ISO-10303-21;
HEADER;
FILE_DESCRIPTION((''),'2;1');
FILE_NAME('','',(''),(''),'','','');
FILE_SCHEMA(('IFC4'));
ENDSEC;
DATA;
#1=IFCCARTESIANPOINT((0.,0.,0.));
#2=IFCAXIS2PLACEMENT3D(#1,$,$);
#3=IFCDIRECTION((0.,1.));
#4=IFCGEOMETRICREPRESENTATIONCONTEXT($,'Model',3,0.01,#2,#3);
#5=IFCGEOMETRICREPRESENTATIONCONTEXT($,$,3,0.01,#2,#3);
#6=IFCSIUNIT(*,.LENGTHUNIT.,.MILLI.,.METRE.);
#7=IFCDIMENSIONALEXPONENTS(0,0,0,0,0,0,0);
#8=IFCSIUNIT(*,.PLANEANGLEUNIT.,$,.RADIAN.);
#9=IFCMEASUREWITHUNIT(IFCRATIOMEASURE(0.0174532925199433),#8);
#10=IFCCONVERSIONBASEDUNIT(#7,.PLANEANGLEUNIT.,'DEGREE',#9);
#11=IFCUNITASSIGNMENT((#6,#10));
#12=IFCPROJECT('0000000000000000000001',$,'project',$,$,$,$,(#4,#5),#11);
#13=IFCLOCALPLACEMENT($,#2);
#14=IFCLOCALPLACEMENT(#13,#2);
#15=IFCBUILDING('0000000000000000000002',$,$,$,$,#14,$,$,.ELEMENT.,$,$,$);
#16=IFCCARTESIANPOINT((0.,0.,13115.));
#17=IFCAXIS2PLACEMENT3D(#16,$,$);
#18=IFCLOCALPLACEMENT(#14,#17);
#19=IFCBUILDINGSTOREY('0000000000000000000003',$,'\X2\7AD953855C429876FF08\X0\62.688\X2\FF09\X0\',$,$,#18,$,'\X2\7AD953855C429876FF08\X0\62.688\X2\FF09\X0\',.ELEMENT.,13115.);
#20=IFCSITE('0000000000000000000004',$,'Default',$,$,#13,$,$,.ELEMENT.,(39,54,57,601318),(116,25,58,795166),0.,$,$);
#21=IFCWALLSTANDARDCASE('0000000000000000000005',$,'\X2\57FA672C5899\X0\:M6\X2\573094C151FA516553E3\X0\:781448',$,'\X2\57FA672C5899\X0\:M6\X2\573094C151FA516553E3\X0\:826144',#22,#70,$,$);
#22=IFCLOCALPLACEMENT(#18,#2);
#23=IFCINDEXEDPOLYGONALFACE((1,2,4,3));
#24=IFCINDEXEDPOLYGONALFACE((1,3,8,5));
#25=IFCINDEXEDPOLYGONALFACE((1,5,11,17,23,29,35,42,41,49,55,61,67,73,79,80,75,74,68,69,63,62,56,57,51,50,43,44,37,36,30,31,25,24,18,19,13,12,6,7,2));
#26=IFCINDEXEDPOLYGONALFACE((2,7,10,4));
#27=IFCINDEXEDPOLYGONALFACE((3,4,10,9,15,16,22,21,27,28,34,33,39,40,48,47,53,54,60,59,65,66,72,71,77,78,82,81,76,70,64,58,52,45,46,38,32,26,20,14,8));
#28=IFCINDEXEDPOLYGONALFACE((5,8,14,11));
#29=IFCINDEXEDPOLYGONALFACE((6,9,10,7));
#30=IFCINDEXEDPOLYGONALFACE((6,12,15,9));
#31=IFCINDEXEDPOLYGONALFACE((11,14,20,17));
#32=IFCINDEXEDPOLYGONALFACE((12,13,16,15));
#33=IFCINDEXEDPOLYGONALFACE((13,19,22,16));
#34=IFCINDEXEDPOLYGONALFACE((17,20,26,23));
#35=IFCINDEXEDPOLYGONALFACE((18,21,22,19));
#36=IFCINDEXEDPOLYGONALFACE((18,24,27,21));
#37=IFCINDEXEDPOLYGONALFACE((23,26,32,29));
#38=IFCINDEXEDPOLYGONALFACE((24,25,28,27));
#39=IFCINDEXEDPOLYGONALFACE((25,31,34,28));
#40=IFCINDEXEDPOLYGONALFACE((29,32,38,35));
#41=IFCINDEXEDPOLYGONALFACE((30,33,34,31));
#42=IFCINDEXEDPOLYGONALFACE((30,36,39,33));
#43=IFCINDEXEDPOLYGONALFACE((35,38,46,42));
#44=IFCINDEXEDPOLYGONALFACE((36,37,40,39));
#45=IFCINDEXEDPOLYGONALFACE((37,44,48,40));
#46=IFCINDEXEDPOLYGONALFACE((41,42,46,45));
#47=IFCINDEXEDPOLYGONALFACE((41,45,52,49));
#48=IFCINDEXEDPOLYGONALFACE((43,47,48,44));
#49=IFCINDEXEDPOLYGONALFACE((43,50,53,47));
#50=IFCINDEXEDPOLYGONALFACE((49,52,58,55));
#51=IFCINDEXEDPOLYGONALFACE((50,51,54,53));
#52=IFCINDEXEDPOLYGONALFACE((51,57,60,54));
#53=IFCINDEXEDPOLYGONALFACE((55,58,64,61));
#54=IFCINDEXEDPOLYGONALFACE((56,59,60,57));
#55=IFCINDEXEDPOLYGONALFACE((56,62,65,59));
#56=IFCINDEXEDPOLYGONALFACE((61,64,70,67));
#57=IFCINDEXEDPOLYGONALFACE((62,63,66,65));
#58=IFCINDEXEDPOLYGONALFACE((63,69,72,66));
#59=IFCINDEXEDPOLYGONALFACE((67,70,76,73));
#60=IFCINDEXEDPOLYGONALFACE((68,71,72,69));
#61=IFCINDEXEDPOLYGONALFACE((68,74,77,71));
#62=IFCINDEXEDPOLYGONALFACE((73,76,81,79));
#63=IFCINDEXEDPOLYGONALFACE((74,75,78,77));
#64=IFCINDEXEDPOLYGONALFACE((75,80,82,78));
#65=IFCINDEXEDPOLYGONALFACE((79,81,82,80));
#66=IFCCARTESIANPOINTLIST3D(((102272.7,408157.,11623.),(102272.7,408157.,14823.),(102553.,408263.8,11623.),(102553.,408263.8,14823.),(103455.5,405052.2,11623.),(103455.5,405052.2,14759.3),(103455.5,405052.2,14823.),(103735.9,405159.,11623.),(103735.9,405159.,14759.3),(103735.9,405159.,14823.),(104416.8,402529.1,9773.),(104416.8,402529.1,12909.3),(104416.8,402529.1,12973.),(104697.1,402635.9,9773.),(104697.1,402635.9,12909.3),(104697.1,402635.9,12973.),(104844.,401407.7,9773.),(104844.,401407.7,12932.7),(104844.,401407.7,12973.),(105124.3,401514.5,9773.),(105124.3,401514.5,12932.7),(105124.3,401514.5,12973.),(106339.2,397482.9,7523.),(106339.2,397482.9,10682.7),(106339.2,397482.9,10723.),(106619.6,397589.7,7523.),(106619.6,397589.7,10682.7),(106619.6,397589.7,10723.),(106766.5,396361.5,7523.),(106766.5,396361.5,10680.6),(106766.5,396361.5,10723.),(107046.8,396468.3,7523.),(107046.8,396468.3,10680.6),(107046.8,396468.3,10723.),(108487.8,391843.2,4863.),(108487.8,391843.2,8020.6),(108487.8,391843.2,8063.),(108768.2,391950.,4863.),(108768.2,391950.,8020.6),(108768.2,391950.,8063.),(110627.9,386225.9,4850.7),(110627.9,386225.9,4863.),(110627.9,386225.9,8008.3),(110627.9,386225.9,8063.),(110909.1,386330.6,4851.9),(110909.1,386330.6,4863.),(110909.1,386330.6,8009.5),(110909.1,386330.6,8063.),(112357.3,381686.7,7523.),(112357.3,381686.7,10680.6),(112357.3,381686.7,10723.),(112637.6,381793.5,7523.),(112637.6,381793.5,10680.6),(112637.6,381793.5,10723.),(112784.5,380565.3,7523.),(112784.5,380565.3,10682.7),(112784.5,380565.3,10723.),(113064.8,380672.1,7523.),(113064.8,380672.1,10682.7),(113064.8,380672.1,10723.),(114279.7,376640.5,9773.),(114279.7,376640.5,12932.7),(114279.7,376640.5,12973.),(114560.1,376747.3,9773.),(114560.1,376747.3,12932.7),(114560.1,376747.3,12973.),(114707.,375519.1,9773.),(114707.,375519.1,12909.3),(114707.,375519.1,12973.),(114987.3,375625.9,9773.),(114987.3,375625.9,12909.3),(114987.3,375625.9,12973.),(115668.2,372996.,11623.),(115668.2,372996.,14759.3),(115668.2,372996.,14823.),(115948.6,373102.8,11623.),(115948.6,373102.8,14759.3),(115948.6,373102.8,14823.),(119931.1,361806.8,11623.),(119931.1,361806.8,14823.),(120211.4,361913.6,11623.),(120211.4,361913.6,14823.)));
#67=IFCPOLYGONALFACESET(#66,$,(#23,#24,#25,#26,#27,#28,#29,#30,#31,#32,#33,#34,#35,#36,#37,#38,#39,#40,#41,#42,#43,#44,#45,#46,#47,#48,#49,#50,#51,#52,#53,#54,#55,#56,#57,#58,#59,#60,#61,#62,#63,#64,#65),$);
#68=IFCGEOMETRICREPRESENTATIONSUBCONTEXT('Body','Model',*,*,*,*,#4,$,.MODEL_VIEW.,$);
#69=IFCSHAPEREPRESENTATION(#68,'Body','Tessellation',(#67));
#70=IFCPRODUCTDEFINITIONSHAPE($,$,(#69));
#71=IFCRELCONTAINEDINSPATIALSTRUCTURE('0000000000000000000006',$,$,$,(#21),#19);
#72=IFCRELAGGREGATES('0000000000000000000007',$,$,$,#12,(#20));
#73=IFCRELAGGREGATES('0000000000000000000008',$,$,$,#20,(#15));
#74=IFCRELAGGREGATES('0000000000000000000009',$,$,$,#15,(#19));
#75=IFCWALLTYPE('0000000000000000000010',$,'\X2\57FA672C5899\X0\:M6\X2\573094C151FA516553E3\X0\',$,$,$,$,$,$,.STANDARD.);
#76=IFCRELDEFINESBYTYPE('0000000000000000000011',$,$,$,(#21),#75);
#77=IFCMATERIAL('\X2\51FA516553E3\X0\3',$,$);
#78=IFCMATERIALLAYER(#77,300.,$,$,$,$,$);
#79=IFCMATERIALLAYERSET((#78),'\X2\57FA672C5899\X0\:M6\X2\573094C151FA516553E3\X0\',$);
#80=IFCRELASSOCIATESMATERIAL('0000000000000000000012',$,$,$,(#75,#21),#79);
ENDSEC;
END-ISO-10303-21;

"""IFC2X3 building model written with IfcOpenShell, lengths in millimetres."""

from ifc_helpers import new_model, entity, si_unit, converted_unit, direction, frame, frame_2d, origin, place, context, subcontext, project, spatial, polyline, rectangle, extrude, clip, bounded_halfspace, material, layer, layer_set, layer_usage, type_object, element, save


model = new_model("IFC2X3")

# Units and contexts
model_context = context("Model", 3, precision=0.01, world=origin(), true_north=direction((0.0, 1.0)))
context_of_model = context(None, 3, precision=0.01, world=origin(), true_north=direction((0.0, 1.0)))
body_context = subcontext(model_context, "Body", "Model", "MODEL_VIEW")
ifc_project = project(units=[si_unit("LENGTHUNIT", "METRE", prefix="MILLI"), converted_unit("PLANEANGLEUNIT", "DEGREE", entity("IfcRatioMeasure", 0.0174532925199433), si_unit("PLANEANGLEUNIT", "RADIAN"), dimensions=[0, 0, 0, 0, 0, 0, 0])], contexts=[model_context, context_of_model])

# Site, building, storey
site_placement = place(None, origin())
site = spatial("IfcSite", under=ifc_project, at=site_placement, Name="Default", CompositionType="ELEMENT", RefLatitude=(39, 54, 57, 601318), RefLongitude=(116, 25, 58, 795166), RefElevation=0.0)
building_placement = place(site_placement, origin())
building = spatial("IfcBuilding", under=site, at=building_placement, CompositionType="ELEMENT")
storey_placement = place(building_placement, frame((0.0, 0.0, 13115.0)))
storey = spatial("IfcBuildingStorey", under=building, at=storey_placement, Name="站厅层顶（62.688）", LongName="站厅层顶（62.688）", CompositionType="ELEMENT", Elevation=13115.0)

# Wall
ifc_material_1 = material(Name="出入口3")
ifc_layer_1 = layer(ifc_material_1, 300.0)
ifc_layer_set_1 = layer_set([ifc_layer_1], Name="基本墙:M6地铁出入口")
wall_type = type_object("IfcWallType", Name="基本墙:M6地铁出入口", PredefinedType="STANDARD", material=ifc_layer_set_1)
ifc_layer_usage_1 = layer_usage(ifc_layer_set_1, "AXIS2", "NEGATIVE", 150.0)
wall_1_placement = place(storey_placement, frame((102412.8, 408210.4, 0.0), z_axis=(0.0, 0.0, 1.0), x_axis=(0.356017, -0.93448, 0.0)))
solid_1 = clip(clip(clip(clip(clip(clip(clip(clip(extrude(rectangle(XDim=49600.0, YDim=300.0, at=frame_2d((24800.0, 0.0), x_axis=(-1.0, 0.0))), origin(), (0.0, 0.0, 1.0), 14823.0), bounded_halfspace(frame((0.0, -150.0, 14823.0), z_axis=(0.0, 0.0, -1.0), x_axis=(0.0, -1.0, 0.0)), True, frame((0.0, -150.0, 14823.0)), polyline([(0.0, 0.0), (3322.5, 0.0), (3322.5, 300.0), (0.0, 300.0), (0.0, 0.0)]))), bounded_halfspace(frame((3322.5, -150.0, 14759.3), z_axis=(-0.565231, 0.0, -0.824932), x_axis=(0.824932, 0.0, -0.565231)), True, frame((3322.5, -150.0, 14759.3)), polyline([(0.0, 0.0), (2700.0, 0.0), (2700.0, 300.0), (0.0, 300.0), (0.0, 0.0)]))), bounded_halfspace(frame((6022.5, -150.0, 12973.0), z_axis=(0.0, 0.0, -1.0), x_axis=(0.0, 1.0, 0.0)), True, frame((6022.5, -150.0, 12973.0)), polyline([(0.0, 0.0), (1200.0, 0.0), (1200.0, 300.0), (0.0, 300.0), (0.0, 0.0)]))), bounded_halfspace(frame((7222.5, -150.0, 12932.7), z_axis=(-0.472221, 0.0, -0.88148), x_axis=(0.88148, 0.0, -0.472221)), True, frame((7222.5, -150.0, 12932.7)), polyline([(0.0, 0.0), (4200.0, 0.0), (4200.0, 300.0), (0.0, 300.0), (0.0, 0.0)]))), bounded_halfspace(frame((28326.2, -150.0, 10723.0), z_axis=(0.0, 0.0, -1.0), x_axis=(-1.0, 0.000005, 0.0)), True, frame((28326.2, -150.0, 10723.0)), polyline([(0.0, 0.0), (1200.0, 0.0), (1200.0, 300.0), (0.0, 300.0), (0.0, 0.0)]))), bounded_halfspace(frame((29526.2, -150.0, 10682.7), z_axis=(0.472221, -0.000002, -0.88148), x_axis=(-0.88148, 0.000004, -0.472221)), True, frame((29526.2, -150.0, 10682.7)), polyline([(0.0, 0.0), (4200.0, 0.0), (4200.0, 300.0), (0.0, 300.0), (0.0, 0.0)]))), bounded_halfspace(frame((11422.5, -150.0, 10723.0), z_axis=(0.0, 0.0, -1.0), x_axis=(0.0, 1.0, 0.0)), True, frame((11422.5, -150.0, 10723.0)), polyline([(0.0, 0.0), (1200.0, 0.0), (1200.0, 300.0), (0.0, 300.0), (0.0, 0.0)]))), bounded_halfspace(frame((12622.5, -150.0, 10680.6), z_axis=(-0.482018, 0.0, -0.876161), x_axis=(0.876161, 0.0, -0.482018)), True, frame((12622.5, -150.0, 10680.6)), polyline([(0.0, 0.0), (4835.1, 0.0), (4835.1, 300.0), (0.0, 300.0), (0.0, 0.0)])))
solid_2 = clip(clip(clip(clip(clip(clip(clip(clip(solid_1, bounded_halfspace(frame((17457.6, -150.0, 8063.0), z_axis=(0.0, 0.0, -1.0), x_axis=(0.0, 1.0, 0.0)), True, frame((17457.6, -150.0, 8063.0)), polyline([(0.0, 0.0), (6011.2, 0.0), (6013.4, 300.0), (0.0, 300.0), (0.0, 0.0)]))), bounded_halfspace(frame((23468.8, -150.0, 8008.3), z_axis=(0.482018, -0.000002, -0.876161), x_axis=(-0.876161, 0.000004, -0.482018)), True, frame((23468.8, -150.0, 8008.3)), polyline([(0.0, 0.0), (4857.5, 0.0), (4857.5, 300.0), (2.2, 300.0), (0.0, 0.0)]))), bounded_halfspace(frame((33726.2, -150.0, 12973.0), z_axis=(0.0, 0.0, -1.0), x_axis=(-1.0, 0.000005, 0.0)), True, frame((33726.2, -150.0, 12973.0)), polyline([(0.0, 0.0), (1200.0, 0.0), (1200.0, 300.0), (0.0, 300.0), (0.0, 0.0)]))), bounded_halfspace(frame((34926.2, -150.0, 12909.3), z_axis=(0.565231, -0.000003, -0.824932), x_axis=(-0.824932, 0.000004, -0.565231)), True, frame((34926.2, -150.0, 12909.3)), polyline([(0.0, 0.0), (2700.0, 0.0), (2700.0, 300.0), (0.0, 300.0), (0.0, 0.0)]))), bounded_halfspace(frame((37626.2, -150.0, 14823.0), z_axis=(0.0, 0.0, -1.0), x_axis=(0.000005, 1.0, 0.0)), True, frame((37626.2, -150.0, 14823.0)), polyline([(0.0, 0.0), (11973.8, 0.0), (11973.8, 300.0), (0.0, 300.0), (0.0, 0.0)]))), bounded_halfspace(frame((12622.5, -150.0, 7523.0), z_axis=(0.0, 0.0, 1.0), x_axis=(0.0, -1.0, 0.0)), True, frame((12622.5, -150.0, 7523.0)), polyline([(0.0, 0.0), (0.0, 300.0), (-1200.0, 300.0), (-1200.0, 0.0), (0.0, 0.0)]))), bounded_halfspace(frame((17457.6, -150.0, 4863.0), z_axis=(0.482018, 0.0, 0.876161), x_axis=(-0.876161, 0.0, 0.482018)), True, frame((17457.6, -150.0, 4863.0)), polyline([(0.0, 0.0), (0.0, 300.0), (-4835.1, 300.0), (-4835.1, 0.0), (0.0, 0.0)]))), bounded_halfspace(frame((23468.8, -150.0, 4863.0), z_axis=(0.0, 0.0, 1.0), x_axis=(0.0, -1.0, 0.0)), True, frame((23468.8, -150.0, 4863.0)), polyline([(0.0, 0.0), (2.2, 300.0), (-6011.2, 300.0), (-6011.2, 0.0), (-5146.3, 0.0), (-4496.3, 0.0), (-1546.3, 0.0), (-896.3, 0.0), (0.0, 0.0)])))
solid_3 = clip(clip(clip(clip(clip(clip(clip(clip(solid_2, bounded_halfspace(frame((28326.2, -150.0, 7523.0), z_axis=(-0.482018, 0.000002, 0.876161), x_axis=(0.876161, -0.000004, 0.482018)), True, frame((28326.2, -150.0, 7523.0)), polyline([(0.0, 0.0), (0.0, 300.0), (-4855.2, 300.0), (-4857.5, 0.0), (0.0, 0.0)]))), bounded_halfspace(frame((34926.2, -150.0, 9773.0)), True, frame((34926.2, -150.0, 9773.0)), polyline([(0.0, 0.0), (0.0, 300.0), (-1200.0, 300.0), (-1200.0, 0.0), (0.0, 0.0)]))), bounded_halfspace(frame((49600.0, -150.0, 11623.0), z_axis=(0.0, 0.0, 1.0), x_axis=(-0.000005, -1.0, 0.0)), True, frame((49600.0, -150.0, 11623.0)), polyline([(0.0, 0.0), (0.0, 300.0), (-11973.8, 300.0), (-11973.8, 0.0), (0.0, 0.0)]))), bounded_halfspace(frame((37626.2, -150.0, 11623.0), z_axis=(-0.565231, 0.000003, 0.824932), x_axis=(0.824932, -0.000004, 0.565231)), True, frame((37626.2, -150.0, 11623.0)), polyline([(0.0, 0.0), (0.0, 300.0), (-2700.0, 300.0), (-2700.0, 0.0), (0.0, 0.0)]))), bounded_halfspace(frame((6022.5, -150.0, 9773.0), z_axis=(0.565231, 0.0, 0.824932), x_axis=(-0.824932, 0.0, 0.565231)), True, frame((6022.5, -150.0, 9773.0)), polyline([(0.0, 0.0), (0.0, 300.0), (-2700.0, 300.0), (-2700.0, 0.0), (0.0, 0.0)]))), bounded_halfspace(frame((3322.5, -150.0, 11623.0), z_axis=(0.0, 0.0, 1.0), x_axis=(0.0, 1.0, 0.0)), True, frame((3322.5, -150.0, 11623.0)), polyline([(0.0, 0.0), (0.0, 300.0), (-3322.5, 300.0), (-3322.5, 0.0), (0.0, 0.0)]))), bounded_halfspace(frame((7222.5, -150.0, 9773.0), z_axis=(0.0, 0.0, 1.0), x_axis=(0.0, -1.0, 0.0)), True, frame((7222.5, -150.0, 9773.0)), polyline([(0.0, 0.0), (0.0, 300.0), (-1200.0, 300.0), (-1200.0, 0.0), (0.0, 0.0)]))), bounded_halfspace(frame((11422.5, -150.0, 7523.0), z_axis=(0.472221, 0.0, 0.88148), x_axis=(-0.88148, 0.0, 0.472221)), True, frame((11422.5, -150.0, 7523.0)), polyline([(0.0, 0.0), (0.0, 300.0), (-4200.0, 300.0), (-4200.0, 0.0), (0.0, 0.0)])))
element("IfcWallStandardCase", 1, at=wall_1_placement, inside=storey, type_object=wall_type, material=ifc_layer_usage_1, Name="基本墙:M6地铁出入口:781448", ObjectType="基本墙:M6地铁出入口:826144", context=body_context, shape_type="Clipping", body=[
    clip(clip(clip(clip(solid_3, bounded_halfspace(frame((29526.2, -150.0, 7523.0)), True, frame((29526.2, -150.0, 7523.0)), polyline([(0.0, 0.0), (0.0, 300.0), (-1200.0, 300.0), (-1200.0, 0.0), (0.0, 0.0)]))), bounded_halfspace(frame((33726.2, -150.0, 9773.0), z_axis=(-0.472221, 0.000002, 0.88148), x_axis=(0.88148, -0.000004, 0.472221)), True, frame((33726.2, -150.0, 9773.0)), polyline([(0.0, 0.0), (0.0, 300.0), (-4200.0, 300.0), (-4200.0, 0.0), (0.0, 0.0)]))), bounded_halfspace(frame((6022.5, -150.0, 12973.0), z_axis=(0.0, 0.0, -1.0), x_axis=(0.0, 1.0, 0.0)), True, frame((6022.5, -150.0, 12973.0)), polyline([(0.0, 0.0), (1200.0, 0.0), (1200.0, 300.0), (0.0, 300.0), (0.0, 0.0)]))), bounded_halfspace(frame((33726.2, -150.0, 12973.0), z_axis=(0.0, 0.0, -1.0), x_axis=(-1.0, 0.000005, 0.0)), True, frame((33726.2, -150.0, 12973.0)), polyline([(0.0, 0.0), (1200.0, 0.0), (1200.0, 300.0), (0.0, 300.0), (0.0, 0.0)]))),
])

save(model, "model.ifc")
